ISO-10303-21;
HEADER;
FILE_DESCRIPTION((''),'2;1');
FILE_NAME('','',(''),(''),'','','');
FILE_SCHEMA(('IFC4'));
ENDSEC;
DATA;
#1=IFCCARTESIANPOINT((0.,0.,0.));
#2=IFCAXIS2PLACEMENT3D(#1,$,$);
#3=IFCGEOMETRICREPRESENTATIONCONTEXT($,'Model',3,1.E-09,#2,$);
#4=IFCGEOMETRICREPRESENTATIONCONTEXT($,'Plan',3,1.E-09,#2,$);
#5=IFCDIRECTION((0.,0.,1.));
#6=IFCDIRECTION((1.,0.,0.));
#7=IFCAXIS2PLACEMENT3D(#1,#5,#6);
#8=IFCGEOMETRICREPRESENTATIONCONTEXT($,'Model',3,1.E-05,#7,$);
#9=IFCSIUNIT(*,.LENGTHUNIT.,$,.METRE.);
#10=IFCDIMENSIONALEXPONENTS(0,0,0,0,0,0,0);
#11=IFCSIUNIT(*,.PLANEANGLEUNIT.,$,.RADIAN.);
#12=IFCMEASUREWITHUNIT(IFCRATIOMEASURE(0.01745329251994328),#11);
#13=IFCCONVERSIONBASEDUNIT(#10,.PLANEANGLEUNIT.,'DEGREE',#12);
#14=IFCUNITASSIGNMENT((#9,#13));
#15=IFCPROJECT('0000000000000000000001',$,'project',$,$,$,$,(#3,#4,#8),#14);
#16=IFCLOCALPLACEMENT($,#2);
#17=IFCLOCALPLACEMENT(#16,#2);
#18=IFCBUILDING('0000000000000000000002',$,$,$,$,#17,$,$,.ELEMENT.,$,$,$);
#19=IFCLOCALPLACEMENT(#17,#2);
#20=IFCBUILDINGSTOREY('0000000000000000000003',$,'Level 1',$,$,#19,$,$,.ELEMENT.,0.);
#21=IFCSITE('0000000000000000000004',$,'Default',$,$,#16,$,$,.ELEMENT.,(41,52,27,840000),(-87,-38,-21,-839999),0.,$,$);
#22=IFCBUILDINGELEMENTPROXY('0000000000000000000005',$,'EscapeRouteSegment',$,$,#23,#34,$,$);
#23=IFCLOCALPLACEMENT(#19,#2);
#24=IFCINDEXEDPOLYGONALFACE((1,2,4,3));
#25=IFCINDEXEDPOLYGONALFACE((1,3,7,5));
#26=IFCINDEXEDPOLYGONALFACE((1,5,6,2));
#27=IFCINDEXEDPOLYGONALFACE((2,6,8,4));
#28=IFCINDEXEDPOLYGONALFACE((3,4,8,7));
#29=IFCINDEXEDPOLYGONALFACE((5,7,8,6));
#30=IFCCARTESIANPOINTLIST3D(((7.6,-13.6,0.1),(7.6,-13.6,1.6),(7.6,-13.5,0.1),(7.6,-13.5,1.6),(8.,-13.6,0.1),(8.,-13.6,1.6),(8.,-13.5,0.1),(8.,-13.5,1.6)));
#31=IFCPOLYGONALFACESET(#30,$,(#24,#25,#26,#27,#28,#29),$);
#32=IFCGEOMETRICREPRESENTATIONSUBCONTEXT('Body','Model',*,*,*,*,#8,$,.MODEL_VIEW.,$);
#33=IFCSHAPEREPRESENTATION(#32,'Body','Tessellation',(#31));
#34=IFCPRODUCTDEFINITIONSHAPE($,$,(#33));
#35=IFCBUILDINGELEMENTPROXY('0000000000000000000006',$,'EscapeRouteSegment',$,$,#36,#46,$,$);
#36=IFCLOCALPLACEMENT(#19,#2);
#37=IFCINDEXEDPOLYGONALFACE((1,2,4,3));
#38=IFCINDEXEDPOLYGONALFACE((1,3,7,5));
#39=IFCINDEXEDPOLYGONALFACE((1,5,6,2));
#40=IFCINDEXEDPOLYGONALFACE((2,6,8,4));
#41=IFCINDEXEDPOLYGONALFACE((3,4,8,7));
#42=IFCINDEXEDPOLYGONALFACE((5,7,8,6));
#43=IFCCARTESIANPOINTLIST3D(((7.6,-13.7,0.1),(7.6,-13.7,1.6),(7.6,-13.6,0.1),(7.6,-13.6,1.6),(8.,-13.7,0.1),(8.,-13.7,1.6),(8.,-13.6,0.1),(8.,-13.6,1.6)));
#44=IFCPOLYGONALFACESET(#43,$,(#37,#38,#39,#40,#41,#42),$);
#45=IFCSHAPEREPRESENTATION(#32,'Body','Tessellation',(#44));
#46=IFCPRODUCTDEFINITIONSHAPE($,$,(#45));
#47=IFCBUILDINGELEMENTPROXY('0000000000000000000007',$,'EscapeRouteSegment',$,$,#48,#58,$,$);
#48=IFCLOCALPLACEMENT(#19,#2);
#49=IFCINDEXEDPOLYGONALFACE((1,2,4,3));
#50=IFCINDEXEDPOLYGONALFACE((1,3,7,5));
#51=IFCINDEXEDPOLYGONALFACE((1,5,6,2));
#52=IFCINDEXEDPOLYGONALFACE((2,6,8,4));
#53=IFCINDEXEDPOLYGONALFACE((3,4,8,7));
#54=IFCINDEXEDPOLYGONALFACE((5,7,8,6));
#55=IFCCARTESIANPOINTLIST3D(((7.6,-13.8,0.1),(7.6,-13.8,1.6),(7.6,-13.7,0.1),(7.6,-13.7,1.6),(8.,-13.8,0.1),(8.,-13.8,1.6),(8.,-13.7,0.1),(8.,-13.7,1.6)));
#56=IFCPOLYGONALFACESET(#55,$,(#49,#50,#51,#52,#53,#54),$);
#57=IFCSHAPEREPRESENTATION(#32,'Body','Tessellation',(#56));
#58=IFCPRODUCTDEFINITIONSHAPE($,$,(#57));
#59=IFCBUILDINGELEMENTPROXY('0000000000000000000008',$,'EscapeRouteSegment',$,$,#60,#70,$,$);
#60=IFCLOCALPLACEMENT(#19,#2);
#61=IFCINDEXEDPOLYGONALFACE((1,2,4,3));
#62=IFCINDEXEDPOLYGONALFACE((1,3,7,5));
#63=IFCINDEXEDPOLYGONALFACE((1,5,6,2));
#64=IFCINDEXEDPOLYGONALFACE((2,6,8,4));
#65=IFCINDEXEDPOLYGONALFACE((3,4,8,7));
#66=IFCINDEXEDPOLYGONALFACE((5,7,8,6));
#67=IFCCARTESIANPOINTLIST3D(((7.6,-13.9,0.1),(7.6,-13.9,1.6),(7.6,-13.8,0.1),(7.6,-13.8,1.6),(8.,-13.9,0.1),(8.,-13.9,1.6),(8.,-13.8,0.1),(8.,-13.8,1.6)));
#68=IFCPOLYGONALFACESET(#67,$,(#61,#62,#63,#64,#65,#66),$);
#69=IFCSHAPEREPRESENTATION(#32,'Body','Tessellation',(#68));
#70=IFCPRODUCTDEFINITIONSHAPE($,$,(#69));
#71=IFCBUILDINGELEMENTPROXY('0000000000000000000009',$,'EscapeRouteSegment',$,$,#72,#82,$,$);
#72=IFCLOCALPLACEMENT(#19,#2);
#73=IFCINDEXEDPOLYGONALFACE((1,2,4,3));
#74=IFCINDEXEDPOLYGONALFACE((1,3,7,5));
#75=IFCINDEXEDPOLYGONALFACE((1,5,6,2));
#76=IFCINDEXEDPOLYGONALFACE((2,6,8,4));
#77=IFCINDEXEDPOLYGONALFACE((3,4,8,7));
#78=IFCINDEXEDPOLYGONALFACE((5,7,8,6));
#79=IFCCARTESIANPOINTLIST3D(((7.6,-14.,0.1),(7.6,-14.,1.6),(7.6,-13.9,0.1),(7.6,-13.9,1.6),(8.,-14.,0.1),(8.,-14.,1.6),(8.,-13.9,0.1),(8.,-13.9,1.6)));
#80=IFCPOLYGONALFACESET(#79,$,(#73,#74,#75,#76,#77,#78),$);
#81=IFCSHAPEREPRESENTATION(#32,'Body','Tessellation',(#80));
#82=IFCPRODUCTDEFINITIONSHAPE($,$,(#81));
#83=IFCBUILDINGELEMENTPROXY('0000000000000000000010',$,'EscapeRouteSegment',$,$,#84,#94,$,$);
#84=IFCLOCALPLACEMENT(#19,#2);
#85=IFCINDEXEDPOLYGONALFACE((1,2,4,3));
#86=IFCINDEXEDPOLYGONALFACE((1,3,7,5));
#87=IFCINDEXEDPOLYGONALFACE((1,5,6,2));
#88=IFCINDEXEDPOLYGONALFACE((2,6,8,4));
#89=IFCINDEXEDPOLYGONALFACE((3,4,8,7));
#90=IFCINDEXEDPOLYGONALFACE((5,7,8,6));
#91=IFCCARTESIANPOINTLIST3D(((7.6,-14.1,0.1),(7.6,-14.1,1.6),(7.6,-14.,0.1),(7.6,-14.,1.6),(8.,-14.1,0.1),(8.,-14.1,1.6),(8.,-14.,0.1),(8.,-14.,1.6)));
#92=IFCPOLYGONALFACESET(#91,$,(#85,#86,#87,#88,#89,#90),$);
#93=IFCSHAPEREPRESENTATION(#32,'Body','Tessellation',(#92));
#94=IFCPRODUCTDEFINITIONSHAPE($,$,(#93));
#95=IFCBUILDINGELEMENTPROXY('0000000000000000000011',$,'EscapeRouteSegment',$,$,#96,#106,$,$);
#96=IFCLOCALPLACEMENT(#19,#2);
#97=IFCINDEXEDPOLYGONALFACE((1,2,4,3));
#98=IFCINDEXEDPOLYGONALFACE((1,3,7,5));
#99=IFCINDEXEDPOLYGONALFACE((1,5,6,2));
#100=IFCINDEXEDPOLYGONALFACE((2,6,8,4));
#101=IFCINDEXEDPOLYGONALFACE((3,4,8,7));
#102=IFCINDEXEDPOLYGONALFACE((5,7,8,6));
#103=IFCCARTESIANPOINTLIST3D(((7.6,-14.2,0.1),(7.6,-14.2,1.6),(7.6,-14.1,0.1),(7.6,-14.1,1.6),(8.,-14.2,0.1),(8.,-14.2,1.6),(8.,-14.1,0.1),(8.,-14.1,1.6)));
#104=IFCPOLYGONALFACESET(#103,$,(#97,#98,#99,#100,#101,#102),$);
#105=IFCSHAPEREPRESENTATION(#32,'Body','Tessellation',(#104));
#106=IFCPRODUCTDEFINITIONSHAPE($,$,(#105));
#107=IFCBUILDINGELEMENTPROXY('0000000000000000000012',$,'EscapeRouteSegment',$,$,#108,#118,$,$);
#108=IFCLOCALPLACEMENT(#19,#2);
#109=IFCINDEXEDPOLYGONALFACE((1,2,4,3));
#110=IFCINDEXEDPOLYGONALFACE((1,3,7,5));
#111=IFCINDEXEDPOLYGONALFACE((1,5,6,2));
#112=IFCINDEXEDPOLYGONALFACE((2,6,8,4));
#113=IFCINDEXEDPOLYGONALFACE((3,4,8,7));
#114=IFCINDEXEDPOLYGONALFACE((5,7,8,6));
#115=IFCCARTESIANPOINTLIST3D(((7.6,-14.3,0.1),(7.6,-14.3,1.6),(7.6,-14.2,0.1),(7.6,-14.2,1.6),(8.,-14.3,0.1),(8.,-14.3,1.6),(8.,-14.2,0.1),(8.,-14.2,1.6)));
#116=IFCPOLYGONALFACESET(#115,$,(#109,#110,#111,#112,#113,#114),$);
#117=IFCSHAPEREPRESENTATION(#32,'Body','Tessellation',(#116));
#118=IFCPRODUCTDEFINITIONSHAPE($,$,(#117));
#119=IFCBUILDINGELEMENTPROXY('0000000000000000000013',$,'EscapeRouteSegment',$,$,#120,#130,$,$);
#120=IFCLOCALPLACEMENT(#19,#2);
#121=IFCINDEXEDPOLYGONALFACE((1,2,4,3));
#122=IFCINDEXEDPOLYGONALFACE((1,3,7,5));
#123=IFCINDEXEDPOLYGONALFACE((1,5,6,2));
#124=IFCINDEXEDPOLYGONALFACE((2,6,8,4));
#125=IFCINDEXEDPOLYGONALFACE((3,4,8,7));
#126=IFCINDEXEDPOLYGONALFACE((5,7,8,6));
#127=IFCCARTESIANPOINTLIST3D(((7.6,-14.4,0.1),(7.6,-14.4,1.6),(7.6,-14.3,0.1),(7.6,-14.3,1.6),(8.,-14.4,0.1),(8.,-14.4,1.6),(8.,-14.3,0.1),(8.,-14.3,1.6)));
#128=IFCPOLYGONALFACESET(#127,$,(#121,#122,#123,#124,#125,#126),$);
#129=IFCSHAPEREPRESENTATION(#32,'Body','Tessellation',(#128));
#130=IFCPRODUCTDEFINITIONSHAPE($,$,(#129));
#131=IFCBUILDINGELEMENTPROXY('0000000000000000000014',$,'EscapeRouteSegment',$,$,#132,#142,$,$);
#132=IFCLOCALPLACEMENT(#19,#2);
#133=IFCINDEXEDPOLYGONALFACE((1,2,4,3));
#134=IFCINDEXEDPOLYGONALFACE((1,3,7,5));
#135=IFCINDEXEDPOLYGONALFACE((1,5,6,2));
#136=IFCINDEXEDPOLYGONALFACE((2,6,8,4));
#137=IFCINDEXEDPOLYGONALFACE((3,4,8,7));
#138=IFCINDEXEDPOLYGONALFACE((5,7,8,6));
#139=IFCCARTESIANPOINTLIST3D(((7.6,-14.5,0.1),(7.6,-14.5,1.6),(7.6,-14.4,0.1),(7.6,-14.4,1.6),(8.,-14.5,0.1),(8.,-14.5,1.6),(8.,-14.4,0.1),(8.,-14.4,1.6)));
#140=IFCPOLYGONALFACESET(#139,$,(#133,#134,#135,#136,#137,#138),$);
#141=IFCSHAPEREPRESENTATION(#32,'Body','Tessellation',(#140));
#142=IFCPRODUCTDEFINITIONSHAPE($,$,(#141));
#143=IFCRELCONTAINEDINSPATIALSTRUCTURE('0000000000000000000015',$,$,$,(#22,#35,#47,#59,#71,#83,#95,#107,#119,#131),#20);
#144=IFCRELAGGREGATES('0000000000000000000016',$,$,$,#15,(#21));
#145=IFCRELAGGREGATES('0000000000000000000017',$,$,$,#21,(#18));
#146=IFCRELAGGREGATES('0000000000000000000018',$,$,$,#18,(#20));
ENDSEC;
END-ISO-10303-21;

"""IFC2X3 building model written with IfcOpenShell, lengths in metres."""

from ifc_helpers import new_model, entity, si_unit, converted_unit, frame, origin, origin_with_axes, place, context, subcontext, project, spatial, polyline, outline, extrude, element, save


model = new_model("IFC2X3")

# Units and contexts
model_context_1 = context("Model", 3, precision=1e-09, world=origin())
plan_context = context("Plan", 3, precision=1e-09, world=origin())
model_context_2 = context("Model", 3, precision=1e-05, world=origin_with_axes())
body_context = subcontext(model_context_2, "Body", "Model", "MODEL_VIEW")
ifc_project = project(units=[si_unit("LENGTHUNIT", "METRE"), converted_unit("PLANEANGLEUNIT", "DEGREE", entity("IfcRatioMeasure", 0.01745329251994328), si_unit("PLANEANGLEUNIT", "RADIAN"), dimensions=[0, 0, 0, 0, 0, 0, 0])], contexts=[model_context_1, plan_context, model_context_2])

# Site, building, storey
site_placement = place(None, origin())
site = spatial("IfcSite", under=ifc_project, at=site_placement, Name="Default", CompositionType="ELEMENT", RefLatitude=(41, 52, 27, 840000), RefLongitude=(-87, -38, -21, -839999), RefElevation=0.0)
building_placement = place(site_placement, origin())
building = spatial("IfcBuilding", under=site, at=building_placement, CompositionType="ELEMENT")
storey_placement = place(building_placement, origin())
storey = spatial("IfcBuildingStorey", under=building, at=storey_placement, Name="Level 1", CompositionType="ELEMENT", Elevation=0.0)

# Building element proxies
proxy_1_placement = place(storey_placement, frame((7.8, -13.5, 0.1), z_axis=(0.0, 0.0, 1.0), x_axis=(0.0, -1.0, 0.0)))
element("IfcBuildingElementProxy", 1, at=proxy_1_placement, inside=storey, Name="EscapeRouteSegment", context=body_context, shape_type="SweptSolid", body=[
    extrude(outline(polyline([(0.0, -0.2), (0.0, 0.2), (0.1, 0.2), (0.1, -0.2), (0.0, -0.2)])), origin_with_axes(), (0.0, 0.0, 1.0), 1.5),
])
proxy_2_placement = place(storey_placement, frame((7.8, -13.6, 0.1), z_axis=(0.0, 0.0, 1.0), x_axis=(0.0, -1.0, 0.0)))
element("IfcBuildingElementProxy", 2, at=proxy_2_placement, inside=storey, Name="EscapeRouteSegment", context=body_context, shape_type="SweptSolid", body=[
    extrude(outline(polyline([(0.0, -0.2), (0.0, 0.2), (0.1, 0.2), (0.1, -0.2), (0.0, -0.2)])), origin_with_axes(), (0.0, 0.0, 1.0), 1.5),
])
proxy_3_placement = place(storey_placement, frame((7.8, -13.7, 0.1), z_axis=(0.0, 0.0, 1.0), x_axis=(0.0, -1.0, 0.0)))
element("IfcBuildingElementProxy", 3, at=proxy_3_placement, inside=storey, Name="EscapeRouteSegment", context=body_context, shape_type="SweptSolid", body=[
    extrude(outline(polyline([(0.0, -0.2), (0.0, 0.2), (0.1, 0.2), (0.1, -0.2), (0.0, -0.2)])), origin_with_axes(), (0.0, 0.0, 1.0), 1.5),
])
proxy_4_placement = place(storey_placement, frame((7.8, -13.8, 0.1), z_axis=(0.0, 0.0, 1.0), x_axis=(0.0, -1.0, 0.0)))
element("IfcBuildingElementProxy", 4, at=proxy_4_placement, inside=storey, Name="EscapeRouteSegment", context=body_context, shape_type="SweptSolid", body=[
    extrude(outline(polyline([(0.0, -0.2), (0.0, 0.2), (0.1, 0.2), (0.1, -0.2), (0.0, -0.2)])), origin_with_axes(), (0.0, 0.0, 1.0), 1.5),
])
for number, where, z_axis, x_axis, name in (
    (5, (7.8, -13.9, 0.1), (0.0, 0.0, 1.0), (0.0, -1.0, 0.0), "EscapeRouteSegment"),
    (6, (7.8, -14.0, 0.1), (0.0, 0.0, 1.0), (0.0, -1.0, 0.0), "EscapeRouteSegment"),
):
    element("IfcBuildingElementProxy", number, at=place(storey_placement, frame(where, z_axis=z_axis, x_axis=x_axis)), inside=storey, Name=name, context=body_context, shape_type="SweptSolid", body=[
        extrude(outline(polyline([(0.0, -0.2), (0.0, 0.2), (0.1, 0.2), (0.1, -0.2), (0.0, -0.2)])), origin_with_axes(), (0.0, 0.0, 1.0), 1.5),
    ])
proxy_5_placement = place(storey_placement, frame((7.8, -14.1, 0.1), z_axis=(0.0, 0.0, 1.0), x_axis=(0.0, -1.0, 0.0)))
element("IfcBuildingElementProxy", 7, at=proxy_5_placement, inside=storey, Name="EscapeRouteSegment", context=body_context, shape_type="SweptSolid", body=[
    extrude(outline(polyline([(0.0, -0.2), (0.0, 0.2), (0.1, 0.2), (0.1, -0.2), (0.0, -0.2)])), origin_with_axes(), (0.0, 0.0, 1.0), 1.5),
])
proxy_6_placement = place(storey_placement, frame((7.8, -14.2, 0.1), z_axis=(0.0, 0.0, 1.0), x_axis=(0.0, -1.0, 0.0)))
element("IfcBuildingElementProxy", 8, at=proxy_6_placement, inside=storey, Name="EscapeRouteSegment", context=body_context, shape_type="SweptSolid", body=[
    extrude(outline(polyline([(0.0, -0.2), (0.0, 0.2), (0.1, 0.2), (0.1, -0.2), (0.0, -0.2)])), origin_with_axes(), (0.0, 0.0, 1.0), 1.5),
])
proxy_7_placement = place(storey_placement, frame((7.8, -14.3, 0.1), z_axis=(0.0, 0.0, 1.0), x_axis=(0.0, -1.0, 0.0)))
element("IfcBuildingElementProxy", 9, at=proxy_7_placement, inside=storey, Name="EscapeRouteSegment", context=body_context, shape_type="SweptSolid", body=[
    extrude(outline(polyline([(0.0, -0.2), (0.0, 0.2), (0.1, 0.2), (0.1, -0.2), (0.0, -0.2)])), origin_with_axes(), (0.0, 0.0, 1.0), 1.5),
])
proxy_8_placement = place(storey_placement, frame((7.8, -14.4, 0.1), z_axis=(0.0, 0.0, 1.0), x_axis=(0.0, -1.0, 0.0)))
element("IfcBuildingElementProxy", 10, at=proxy_8_placement, inside=storey, Name="EscapeRouteSegment", context=body_context, shape_type="SweptSolid", body=[
    extrude(outline(polyline([(0.0, -0.2), (0.0, 0.2), (0.1, 0.2), (0.1, -0.2), (0.0, -0.2)])), origin_with_axes(), (0.0, 0.0, 1.0), 1.5),
])

save(model, "model.ifc")
